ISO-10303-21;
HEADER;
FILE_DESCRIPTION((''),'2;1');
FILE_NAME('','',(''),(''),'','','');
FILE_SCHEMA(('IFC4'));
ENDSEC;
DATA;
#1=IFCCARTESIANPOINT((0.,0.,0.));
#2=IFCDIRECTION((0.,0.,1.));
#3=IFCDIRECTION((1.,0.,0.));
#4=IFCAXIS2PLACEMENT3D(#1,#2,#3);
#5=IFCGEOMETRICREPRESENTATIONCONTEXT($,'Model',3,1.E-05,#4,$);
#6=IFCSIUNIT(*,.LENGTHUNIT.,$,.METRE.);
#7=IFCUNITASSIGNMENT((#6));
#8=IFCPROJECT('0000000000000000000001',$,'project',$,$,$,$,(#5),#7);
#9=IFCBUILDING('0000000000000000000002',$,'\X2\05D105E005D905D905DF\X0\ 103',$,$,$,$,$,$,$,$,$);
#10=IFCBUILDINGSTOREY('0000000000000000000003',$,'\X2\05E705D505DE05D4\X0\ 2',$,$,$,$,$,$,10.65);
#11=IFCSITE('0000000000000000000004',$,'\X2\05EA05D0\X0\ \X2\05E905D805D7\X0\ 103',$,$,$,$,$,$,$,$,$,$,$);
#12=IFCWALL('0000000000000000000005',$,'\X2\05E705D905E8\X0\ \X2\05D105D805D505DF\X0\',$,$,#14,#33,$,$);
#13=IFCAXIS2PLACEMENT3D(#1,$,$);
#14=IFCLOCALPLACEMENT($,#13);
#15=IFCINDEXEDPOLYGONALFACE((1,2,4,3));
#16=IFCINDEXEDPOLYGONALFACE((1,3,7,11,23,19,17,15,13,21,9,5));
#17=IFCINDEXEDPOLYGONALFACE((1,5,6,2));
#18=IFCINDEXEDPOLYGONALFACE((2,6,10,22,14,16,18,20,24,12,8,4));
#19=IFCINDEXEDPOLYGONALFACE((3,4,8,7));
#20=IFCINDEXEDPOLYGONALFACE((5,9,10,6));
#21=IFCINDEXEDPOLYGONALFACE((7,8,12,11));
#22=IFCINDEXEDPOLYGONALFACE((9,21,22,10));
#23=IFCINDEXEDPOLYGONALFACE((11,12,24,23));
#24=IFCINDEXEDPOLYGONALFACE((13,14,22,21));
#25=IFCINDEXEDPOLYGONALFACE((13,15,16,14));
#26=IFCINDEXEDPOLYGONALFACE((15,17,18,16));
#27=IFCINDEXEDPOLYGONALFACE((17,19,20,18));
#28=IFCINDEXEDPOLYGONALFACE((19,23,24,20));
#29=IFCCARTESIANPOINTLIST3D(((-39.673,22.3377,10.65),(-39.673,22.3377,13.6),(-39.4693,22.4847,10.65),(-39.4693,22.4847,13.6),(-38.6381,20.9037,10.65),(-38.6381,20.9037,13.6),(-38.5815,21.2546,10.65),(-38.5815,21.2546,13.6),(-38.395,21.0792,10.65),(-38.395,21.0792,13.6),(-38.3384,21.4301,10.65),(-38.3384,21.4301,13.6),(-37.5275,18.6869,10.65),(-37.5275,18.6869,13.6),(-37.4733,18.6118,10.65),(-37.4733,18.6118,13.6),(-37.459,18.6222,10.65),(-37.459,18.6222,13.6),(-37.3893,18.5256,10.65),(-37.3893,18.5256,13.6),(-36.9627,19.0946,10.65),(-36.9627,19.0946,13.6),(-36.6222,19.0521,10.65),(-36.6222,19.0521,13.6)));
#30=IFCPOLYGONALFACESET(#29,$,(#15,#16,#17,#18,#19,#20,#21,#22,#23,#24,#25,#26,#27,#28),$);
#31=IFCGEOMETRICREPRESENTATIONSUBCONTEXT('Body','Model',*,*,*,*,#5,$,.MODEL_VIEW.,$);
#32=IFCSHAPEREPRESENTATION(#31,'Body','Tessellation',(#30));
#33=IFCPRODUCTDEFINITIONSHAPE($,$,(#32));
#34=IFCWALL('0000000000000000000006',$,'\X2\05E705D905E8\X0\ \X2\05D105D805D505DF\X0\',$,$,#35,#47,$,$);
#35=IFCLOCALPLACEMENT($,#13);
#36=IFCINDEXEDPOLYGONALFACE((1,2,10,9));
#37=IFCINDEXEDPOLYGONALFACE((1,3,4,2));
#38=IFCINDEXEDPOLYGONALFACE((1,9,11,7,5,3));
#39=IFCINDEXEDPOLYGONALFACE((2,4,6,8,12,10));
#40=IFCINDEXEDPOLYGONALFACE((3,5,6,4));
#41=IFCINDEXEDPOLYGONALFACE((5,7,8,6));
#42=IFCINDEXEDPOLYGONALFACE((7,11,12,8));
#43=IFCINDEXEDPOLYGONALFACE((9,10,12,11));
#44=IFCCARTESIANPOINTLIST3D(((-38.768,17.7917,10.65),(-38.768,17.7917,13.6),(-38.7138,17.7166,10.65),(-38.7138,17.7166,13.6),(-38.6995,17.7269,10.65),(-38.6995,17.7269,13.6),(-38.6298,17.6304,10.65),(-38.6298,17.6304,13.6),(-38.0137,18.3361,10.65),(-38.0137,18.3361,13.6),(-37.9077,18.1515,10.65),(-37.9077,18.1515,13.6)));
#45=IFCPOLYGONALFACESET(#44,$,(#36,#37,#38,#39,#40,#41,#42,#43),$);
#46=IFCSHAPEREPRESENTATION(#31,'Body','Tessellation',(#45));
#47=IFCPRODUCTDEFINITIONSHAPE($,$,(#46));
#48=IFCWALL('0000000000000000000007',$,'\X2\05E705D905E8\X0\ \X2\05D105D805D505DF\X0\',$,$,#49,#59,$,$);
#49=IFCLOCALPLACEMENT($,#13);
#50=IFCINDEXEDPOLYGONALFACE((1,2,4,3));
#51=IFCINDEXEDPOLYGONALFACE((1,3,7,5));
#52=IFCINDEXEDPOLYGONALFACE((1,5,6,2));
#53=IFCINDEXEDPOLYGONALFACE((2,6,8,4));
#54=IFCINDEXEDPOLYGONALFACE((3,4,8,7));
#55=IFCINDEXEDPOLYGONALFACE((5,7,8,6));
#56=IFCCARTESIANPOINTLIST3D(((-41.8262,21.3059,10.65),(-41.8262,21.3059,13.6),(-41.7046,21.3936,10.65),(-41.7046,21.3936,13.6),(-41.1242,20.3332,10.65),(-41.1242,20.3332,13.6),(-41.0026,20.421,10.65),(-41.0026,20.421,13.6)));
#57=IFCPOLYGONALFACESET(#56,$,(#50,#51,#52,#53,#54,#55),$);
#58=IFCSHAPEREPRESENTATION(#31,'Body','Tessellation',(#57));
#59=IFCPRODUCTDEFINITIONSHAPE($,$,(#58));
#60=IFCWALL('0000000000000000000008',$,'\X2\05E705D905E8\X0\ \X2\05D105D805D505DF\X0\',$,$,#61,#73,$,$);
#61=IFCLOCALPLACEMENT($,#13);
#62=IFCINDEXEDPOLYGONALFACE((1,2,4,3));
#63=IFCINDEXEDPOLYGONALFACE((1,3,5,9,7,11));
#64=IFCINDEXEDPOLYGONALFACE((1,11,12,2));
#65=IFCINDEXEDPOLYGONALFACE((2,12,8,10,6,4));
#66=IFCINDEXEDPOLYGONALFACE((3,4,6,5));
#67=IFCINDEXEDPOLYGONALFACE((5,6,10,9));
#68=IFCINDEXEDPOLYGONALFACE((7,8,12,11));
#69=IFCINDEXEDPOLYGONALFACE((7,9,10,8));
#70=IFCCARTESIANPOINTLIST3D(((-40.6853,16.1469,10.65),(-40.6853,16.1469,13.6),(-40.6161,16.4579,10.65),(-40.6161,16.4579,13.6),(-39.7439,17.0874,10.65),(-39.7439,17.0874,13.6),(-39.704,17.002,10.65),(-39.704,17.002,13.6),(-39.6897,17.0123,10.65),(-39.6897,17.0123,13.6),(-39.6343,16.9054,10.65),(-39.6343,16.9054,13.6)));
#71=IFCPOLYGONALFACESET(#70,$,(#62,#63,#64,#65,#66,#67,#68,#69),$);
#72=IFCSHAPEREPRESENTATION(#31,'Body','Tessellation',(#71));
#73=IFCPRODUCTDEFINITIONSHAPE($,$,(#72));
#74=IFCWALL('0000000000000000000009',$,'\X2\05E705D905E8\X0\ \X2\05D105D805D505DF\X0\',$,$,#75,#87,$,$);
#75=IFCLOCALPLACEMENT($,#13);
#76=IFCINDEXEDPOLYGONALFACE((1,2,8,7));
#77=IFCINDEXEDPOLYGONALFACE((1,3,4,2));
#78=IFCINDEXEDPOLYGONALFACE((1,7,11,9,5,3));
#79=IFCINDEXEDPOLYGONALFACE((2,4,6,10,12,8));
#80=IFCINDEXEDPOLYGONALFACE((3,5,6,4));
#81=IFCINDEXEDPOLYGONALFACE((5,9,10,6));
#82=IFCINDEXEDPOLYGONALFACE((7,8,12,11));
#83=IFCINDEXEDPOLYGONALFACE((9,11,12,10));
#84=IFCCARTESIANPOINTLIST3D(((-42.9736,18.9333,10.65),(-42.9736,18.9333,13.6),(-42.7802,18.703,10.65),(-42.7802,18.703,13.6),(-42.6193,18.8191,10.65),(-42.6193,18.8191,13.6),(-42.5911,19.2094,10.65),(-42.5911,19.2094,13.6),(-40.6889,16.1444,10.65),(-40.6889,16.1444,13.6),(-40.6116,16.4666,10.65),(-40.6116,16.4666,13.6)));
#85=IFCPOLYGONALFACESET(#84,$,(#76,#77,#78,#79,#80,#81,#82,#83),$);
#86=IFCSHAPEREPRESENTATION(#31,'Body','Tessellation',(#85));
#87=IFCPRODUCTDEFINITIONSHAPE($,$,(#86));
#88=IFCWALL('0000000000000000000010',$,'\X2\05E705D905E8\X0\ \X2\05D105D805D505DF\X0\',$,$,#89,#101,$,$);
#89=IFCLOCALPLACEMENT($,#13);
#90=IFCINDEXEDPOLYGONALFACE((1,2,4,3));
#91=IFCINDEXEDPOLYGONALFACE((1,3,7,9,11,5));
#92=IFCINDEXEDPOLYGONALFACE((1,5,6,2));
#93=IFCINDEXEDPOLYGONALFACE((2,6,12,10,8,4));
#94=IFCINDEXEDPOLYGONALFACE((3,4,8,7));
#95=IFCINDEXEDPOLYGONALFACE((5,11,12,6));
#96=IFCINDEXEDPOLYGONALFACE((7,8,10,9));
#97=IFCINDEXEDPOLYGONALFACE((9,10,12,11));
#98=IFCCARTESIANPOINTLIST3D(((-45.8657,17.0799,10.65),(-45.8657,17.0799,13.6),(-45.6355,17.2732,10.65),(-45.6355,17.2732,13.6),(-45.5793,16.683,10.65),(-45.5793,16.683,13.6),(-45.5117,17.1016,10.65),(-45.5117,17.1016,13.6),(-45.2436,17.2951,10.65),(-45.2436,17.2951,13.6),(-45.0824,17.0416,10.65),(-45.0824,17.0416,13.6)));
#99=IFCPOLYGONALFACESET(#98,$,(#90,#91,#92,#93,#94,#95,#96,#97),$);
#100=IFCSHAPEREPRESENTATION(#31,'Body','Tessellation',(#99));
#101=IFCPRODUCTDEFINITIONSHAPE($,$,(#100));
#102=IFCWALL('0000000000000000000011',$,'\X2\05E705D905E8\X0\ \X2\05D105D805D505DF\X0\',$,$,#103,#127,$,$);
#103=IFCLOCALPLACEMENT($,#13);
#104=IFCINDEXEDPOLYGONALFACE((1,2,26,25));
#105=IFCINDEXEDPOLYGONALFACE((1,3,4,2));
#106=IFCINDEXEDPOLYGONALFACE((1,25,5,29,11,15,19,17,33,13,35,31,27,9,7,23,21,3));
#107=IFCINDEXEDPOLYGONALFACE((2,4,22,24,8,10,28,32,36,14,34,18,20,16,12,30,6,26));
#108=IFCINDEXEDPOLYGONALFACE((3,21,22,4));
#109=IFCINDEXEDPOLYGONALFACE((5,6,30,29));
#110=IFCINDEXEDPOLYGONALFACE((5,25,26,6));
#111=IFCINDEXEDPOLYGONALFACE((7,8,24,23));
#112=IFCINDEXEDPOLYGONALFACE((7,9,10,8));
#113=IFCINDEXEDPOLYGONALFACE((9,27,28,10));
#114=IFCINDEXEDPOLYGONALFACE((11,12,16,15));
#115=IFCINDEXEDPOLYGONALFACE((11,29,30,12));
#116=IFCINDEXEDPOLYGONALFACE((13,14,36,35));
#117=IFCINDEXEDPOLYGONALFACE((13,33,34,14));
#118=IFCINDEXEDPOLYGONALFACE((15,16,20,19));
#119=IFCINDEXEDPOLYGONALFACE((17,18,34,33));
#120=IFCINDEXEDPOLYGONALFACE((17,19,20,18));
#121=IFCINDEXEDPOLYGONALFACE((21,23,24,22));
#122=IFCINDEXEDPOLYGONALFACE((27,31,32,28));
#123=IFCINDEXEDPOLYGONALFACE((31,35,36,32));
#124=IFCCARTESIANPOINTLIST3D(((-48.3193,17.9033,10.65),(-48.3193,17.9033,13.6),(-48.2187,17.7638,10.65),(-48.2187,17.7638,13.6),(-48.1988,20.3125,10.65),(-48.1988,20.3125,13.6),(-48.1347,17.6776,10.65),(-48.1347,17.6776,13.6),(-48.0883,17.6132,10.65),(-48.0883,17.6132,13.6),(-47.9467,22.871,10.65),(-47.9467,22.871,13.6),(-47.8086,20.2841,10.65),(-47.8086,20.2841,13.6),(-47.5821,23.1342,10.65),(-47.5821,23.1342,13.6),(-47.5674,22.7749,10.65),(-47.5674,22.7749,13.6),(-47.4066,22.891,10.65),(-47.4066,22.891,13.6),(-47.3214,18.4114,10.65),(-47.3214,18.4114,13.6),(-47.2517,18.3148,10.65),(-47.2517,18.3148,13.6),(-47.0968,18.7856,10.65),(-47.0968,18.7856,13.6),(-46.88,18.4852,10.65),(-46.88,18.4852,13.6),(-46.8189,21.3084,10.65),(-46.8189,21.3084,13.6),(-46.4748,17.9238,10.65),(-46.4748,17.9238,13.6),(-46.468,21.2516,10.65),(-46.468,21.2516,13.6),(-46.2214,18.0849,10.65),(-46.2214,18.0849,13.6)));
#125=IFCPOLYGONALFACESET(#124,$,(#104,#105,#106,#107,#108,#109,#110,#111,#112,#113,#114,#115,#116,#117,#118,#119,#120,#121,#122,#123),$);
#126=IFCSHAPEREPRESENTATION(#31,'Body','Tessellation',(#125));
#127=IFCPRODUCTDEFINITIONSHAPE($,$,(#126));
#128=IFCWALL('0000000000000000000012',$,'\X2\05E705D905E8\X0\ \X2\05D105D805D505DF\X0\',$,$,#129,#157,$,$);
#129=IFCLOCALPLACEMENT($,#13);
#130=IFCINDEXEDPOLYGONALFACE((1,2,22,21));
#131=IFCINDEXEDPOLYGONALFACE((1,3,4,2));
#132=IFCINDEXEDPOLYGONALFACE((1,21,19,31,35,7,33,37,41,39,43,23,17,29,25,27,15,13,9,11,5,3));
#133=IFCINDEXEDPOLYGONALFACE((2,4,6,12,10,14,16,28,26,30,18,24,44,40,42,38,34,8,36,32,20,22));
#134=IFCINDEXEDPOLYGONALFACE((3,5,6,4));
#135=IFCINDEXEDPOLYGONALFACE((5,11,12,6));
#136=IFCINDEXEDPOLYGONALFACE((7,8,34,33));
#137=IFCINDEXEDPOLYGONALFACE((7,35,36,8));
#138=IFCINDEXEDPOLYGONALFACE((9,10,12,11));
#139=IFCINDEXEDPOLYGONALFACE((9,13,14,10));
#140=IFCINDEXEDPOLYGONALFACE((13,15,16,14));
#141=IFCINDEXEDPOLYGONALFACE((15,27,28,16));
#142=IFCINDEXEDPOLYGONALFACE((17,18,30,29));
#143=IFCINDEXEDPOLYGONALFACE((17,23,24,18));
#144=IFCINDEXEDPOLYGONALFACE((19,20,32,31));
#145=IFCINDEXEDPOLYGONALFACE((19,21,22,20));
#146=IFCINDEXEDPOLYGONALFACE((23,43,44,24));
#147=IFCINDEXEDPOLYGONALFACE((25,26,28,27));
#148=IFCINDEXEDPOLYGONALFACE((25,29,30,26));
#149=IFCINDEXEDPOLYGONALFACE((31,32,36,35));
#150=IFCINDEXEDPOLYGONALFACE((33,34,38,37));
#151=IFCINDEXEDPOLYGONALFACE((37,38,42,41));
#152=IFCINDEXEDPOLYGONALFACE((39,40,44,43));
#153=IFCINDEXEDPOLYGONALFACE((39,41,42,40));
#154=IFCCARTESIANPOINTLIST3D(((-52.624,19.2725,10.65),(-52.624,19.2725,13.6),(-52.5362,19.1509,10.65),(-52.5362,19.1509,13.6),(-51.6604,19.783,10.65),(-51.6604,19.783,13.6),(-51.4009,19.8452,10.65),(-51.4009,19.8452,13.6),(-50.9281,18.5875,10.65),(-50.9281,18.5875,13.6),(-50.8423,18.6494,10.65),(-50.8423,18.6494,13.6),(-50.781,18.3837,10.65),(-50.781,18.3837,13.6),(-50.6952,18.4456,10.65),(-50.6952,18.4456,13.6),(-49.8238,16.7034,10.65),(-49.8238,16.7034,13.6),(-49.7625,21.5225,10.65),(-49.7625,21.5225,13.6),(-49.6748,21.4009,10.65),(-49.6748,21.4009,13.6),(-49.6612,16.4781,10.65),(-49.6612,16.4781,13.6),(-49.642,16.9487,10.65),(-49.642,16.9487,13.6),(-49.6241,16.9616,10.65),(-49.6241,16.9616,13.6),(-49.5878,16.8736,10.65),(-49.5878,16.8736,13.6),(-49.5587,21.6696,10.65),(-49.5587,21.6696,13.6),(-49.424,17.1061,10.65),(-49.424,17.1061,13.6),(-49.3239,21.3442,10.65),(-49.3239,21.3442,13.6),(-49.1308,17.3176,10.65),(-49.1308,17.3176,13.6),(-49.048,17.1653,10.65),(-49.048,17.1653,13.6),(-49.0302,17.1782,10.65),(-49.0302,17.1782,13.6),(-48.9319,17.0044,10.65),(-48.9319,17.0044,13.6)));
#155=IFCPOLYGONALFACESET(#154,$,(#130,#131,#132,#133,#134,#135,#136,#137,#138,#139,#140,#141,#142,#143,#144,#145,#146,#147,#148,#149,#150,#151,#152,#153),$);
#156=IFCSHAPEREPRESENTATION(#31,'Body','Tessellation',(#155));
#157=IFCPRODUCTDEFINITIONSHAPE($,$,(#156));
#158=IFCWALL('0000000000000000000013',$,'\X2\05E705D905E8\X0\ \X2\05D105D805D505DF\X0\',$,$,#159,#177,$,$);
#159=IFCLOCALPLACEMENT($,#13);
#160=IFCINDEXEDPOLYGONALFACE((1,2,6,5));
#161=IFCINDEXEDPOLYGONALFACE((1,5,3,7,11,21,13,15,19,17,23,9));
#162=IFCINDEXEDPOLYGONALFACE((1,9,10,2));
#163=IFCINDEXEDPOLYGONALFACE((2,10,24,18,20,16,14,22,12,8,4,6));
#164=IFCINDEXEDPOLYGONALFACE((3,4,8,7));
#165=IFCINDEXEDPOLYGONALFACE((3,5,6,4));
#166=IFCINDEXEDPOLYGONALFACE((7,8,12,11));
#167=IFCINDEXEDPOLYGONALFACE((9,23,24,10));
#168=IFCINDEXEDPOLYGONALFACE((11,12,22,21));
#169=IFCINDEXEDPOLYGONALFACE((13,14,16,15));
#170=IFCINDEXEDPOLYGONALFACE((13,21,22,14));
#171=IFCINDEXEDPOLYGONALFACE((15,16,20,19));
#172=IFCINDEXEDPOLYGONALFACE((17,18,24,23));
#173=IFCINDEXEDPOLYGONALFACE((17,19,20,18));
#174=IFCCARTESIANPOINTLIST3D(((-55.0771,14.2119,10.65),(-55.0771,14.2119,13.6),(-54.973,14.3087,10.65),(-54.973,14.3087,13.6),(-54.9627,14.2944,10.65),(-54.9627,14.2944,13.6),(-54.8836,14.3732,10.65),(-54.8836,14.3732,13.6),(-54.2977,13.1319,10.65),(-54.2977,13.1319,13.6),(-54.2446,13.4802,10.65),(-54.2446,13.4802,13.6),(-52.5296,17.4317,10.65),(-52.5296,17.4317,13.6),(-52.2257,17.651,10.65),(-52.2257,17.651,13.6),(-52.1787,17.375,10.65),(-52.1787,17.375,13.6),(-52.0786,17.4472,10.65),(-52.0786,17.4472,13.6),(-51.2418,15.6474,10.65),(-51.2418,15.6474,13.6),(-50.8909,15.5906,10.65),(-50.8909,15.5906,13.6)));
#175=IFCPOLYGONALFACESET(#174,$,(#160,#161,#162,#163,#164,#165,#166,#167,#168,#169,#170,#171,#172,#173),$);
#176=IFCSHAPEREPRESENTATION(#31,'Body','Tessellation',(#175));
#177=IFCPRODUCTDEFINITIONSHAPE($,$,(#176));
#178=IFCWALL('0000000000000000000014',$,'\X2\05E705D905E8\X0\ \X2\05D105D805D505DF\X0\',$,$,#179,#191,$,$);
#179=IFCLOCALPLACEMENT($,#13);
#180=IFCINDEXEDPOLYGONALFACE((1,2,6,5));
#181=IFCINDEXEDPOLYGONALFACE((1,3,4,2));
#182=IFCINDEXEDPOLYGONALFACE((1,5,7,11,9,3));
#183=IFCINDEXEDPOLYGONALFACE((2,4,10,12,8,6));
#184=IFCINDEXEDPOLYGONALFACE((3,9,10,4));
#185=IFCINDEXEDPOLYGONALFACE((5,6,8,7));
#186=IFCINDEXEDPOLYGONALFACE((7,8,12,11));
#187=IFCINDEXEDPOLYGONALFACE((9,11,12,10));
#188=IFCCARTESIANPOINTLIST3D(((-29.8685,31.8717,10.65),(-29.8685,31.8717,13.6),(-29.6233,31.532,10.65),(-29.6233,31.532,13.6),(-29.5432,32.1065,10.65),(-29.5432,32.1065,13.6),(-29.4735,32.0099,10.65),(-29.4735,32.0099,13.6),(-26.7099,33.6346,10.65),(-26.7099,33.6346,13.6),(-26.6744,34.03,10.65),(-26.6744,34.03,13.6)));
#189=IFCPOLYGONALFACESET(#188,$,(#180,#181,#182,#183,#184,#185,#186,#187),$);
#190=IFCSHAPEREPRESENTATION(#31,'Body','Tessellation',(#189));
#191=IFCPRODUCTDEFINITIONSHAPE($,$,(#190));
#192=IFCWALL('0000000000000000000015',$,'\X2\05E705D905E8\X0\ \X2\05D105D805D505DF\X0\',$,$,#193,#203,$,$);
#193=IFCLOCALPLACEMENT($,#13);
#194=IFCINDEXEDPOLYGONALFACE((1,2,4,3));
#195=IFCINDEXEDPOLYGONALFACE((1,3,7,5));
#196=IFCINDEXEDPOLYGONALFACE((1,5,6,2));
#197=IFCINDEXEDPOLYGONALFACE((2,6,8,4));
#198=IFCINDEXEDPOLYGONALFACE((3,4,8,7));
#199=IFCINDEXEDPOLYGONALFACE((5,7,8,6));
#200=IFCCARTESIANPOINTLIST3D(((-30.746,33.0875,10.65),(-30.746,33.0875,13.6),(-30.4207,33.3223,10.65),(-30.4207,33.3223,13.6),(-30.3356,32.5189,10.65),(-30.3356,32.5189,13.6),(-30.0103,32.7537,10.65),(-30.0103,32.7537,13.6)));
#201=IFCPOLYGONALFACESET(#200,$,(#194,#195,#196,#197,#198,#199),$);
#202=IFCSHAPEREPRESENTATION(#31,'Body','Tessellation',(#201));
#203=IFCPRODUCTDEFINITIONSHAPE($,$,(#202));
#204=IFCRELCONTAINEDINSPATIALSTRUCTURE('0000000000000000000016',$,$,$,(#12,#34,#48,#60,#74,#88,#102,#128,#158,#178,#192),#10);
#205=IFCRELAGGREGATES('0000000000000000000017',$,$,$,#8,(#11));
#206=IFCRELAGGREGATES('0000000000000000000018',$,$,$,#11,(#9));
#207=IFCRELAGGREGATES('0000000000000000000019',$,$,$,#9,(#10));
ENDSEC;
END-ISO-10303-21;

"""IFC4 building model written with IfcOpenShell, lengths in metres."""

from ifc_helpers import new_model, si_unit, frame, origin_with_axes, context, subcontext, project, spatial, polyline, outline, extrude, element, save


model = new_model("IFC4")

# Units and contexts
model_context = context("Model", 3, precision=1e-05, world=origin_with_axes())
body_context = subcontext(model_context, "Body", "Model", "MODEL_VIEW")
ifc_project = project(units=[si_unit("LENGTHUNIT", "METRE")], contexts=[model_context])

# Site, building, storey
site = spatial("IfcSite", under=ifc_project, Name="תא שטח 103")
building = spatial("IfcBuilding", under=site, Name="בניין 103")
storey = spatial("IfcBuildingStorey", under=building, Name="קומה 2", Elevation=10.65)

# Walls
element("IfcWall", 1, inside=storey, Name="קיר בטון", context=body_context, shape_type="SweptSolid", body=[
    extrude(outline(polyline([(-37.459, 18.6222), (-37.4733, 18.6118), (-37.5275, 18.6869), (-36.9627, 19.0946), (-38.395, 21.0792), (-38.6381, 20.9037), (-39.673, 22.3377), (-39.4693, 22.4847), (-38.5815, 21.2546), (-38.3384, 21.4301), (-36.6222, 19.0521), (-37.3893, 18.5256), (-37.459, 18.6222)])), frame((0.0, 0.0, 10.65)), (0.0, 0.0, 1.0), 2.95),
])
element("IfcWall", 2, inside=storey, Name="קיר בטון", context=body_context, shape_type="SweptSolid", body=[
    extrude(outline(polyline([(-38.6995, 17.7269), (-38.7138, 17.7166), (-38.768, 17.7917), (-38.0137, 18.3361), (-37.9077, 18.1515), (-38.6298, 17.6304), (-38.6995, 17.7269)])), frame((0.0, 0.0, 10.65)), (0.0, 0.0, 1.0), 2.95),
])
element("IfcWall", 3, inside=storey, Name="קיר בטון", context=body_context, shape_type="SweptSolid", body=[
    extrude(outline(polyline([(-41.0026, 20.421), (-41.1242, 20.3332), (-41.8262, 21.3059), (-41.7046, 21.3936), (-41.0026, 20.421)])), frame((0.0, 0.0, 10.65)), (0.0, 0.0, 1.0), 2.95),
])
element("IfcWall", 4, inside=storey, Name="קיר בטון", context=body_context, shape_type="SweptSolid", body=[
    extrude(outline(polyline([(-40.6161, 16.4579), (-39.7439, 17.0874), (-39.6897, 17.0123), (-39.704, 17.002), (-39.6343, 16.9054), (-40.6853, 16.1469), (-40.6161, 16.4579)])), frame((0.0, 0.0, 10.65)), (0.0, 0.0, 1.0), 2.95),
])
element("IfcWall", 5, inside=storey, Name="קיר בטון", context=body_context, shape_type="SweptSolid", body=[
    extrude(outline(polyline([(-42.5911, 19.2094), (-40.6116, 16.4666), (-40.6889, 16.1444), (-42.6193, 18.8191), (-42.7802, 18.703), (-42.9736, 18.9333), (-42.5911, 19.2094)])), frame((0.0, 0.0, 10.65)), (0.0, 0.0, 1.0), 2.95),
])
element("IfcWall", 6, inside=storey, Name="קיר בטון", context=body_context, shape_type="SweptSolid", body=[
    extrude(outline(polyline([(-45.5793, 16.683), (-45.8657, 17.0799), (-45.6355, 17.2732), (-45.5117, 17.1016), (-45.2436, 17.2951), (-45.0824, 17.0416), (-45.5793, 16.683)])), frame((0.0, 0.0, 10.65)), (0.0, 0.0, 1.0), 2.95),
])
element("IfcWall", 7, inside=storey, Name="קיר בטון", context=body_context, shape_type="SweptSolid", body=[
    extrude(outline(polyline([(-48.3193, 17.9033), (-47.0968, 18.7856), (-48.1988, 20.3125), (-46.8189, 21.3084), (-47.9467, 22.871), (-47.5821, 23.1342), (-47.4066, 22.891), (-47.5674, 22.7749), (-46.468, 21.2516), (-47.8086, 20.2841), (-46.2214, 18.0849), (-46.4748, 17.9238), (-46.88, 18.4852), (-48.0883, 17.6132), (-48.1347, 17.6776), (-47.2517, 18.3148), (-47.3214, 18.4114), (-48.2187, 17.7638), (-48.3193, 17.9033)])), frame((0.0, 0.0, 10.65)), (0.0, 0.0, 1.0), 2.95),
])
element("IfcWall", 8, inside=storey, Name="קיר בטון", context=body_context, shape_type="SweptSolid", body=[
    extrude(outline(polyline([(-49.048, 17.1653), (-48.9319, 17.0044), (-49.6612, 16.4781), (-49.8238, 16.7034), (-49.5878, 16.8736), (-49.642, 16.9487), (-49.6241, 16.9616), (-50.6952, 18.4456), (-50.781, 18.3837), (-50.9281, 18.5875), (-50.8423, 18.6494), (-51.6604, 19.783), (-52.5362, 19.1509), (-52.624, 19.2725), (-49.6748, 21.4009), (-49.7625, 21.5225), (-49.5587, 21.6696), (-49.3239, 21.3442), (-51.4009, 19.8452), (-49.424, 17.1061), (-49.1308, 17.3176), (-49.0302, 17.1782), (-49.048, 17.1653)])), frame((0.0, 0.0, 10.65)), (0.0, 0.0, 1.0), 2.95),
])
element("IfcWall", 9, inside=storey, Name="קיר בטון", context=body_context, shape_type="SweptSolid", body=[
    extrude(outline(polyline([(-54.2977, 13.1319), (-55.0771, 14.2119), (-54.9627, 14.2944), (-54.973, 14.3087), (-54.8836, 14.3732), (-54.2446, 13.4802), (-51.2418, 15.6474), (-52.5296, 17.4317), (-52.2257, 17.651), (-52.0786, 17.4472), (-52.1787, 17.375), (-50.8909, 15.5906), (-54.2977, 13.1319)])), frame((0.0, 0.0, 10.65)), (0.0, 0.0, 1.0), 2.95),
])
element("IfcWall", 10, inside=storey, Name="קיר בטון", context=body_context, shape_type="SweptSolid", body=[
    extrude(outline(polyline([(-26.6744, 34.03), (-26.7099, 33.6346), (-29.6233, 31.532), (-29.8685, 31.8717), (-29.5432, 32.1065), (-29.4735, 32.0099), (-26.6744, 34.03)])), frame((0.0, 0.0, 10.65)), (0.0, 0.0, 1.0), 2.95),
])
element("IfcWall", 11, inside=storey, Name="קיר בטון", context=body_context, shape_type="SweptSolid", body=[
    extrude(outline(polyline([(-30.0103, 32.7537), (-30.3356, 32.5189), (-30.746, 33.0875), (-30.4207, 33.3223), (-30.0103, 32.7537)])), frame((0.0, 0.0, 10.65)), (0.0, 0.0, 1.0), 2.95),
])

save(model, "model.ifc")
